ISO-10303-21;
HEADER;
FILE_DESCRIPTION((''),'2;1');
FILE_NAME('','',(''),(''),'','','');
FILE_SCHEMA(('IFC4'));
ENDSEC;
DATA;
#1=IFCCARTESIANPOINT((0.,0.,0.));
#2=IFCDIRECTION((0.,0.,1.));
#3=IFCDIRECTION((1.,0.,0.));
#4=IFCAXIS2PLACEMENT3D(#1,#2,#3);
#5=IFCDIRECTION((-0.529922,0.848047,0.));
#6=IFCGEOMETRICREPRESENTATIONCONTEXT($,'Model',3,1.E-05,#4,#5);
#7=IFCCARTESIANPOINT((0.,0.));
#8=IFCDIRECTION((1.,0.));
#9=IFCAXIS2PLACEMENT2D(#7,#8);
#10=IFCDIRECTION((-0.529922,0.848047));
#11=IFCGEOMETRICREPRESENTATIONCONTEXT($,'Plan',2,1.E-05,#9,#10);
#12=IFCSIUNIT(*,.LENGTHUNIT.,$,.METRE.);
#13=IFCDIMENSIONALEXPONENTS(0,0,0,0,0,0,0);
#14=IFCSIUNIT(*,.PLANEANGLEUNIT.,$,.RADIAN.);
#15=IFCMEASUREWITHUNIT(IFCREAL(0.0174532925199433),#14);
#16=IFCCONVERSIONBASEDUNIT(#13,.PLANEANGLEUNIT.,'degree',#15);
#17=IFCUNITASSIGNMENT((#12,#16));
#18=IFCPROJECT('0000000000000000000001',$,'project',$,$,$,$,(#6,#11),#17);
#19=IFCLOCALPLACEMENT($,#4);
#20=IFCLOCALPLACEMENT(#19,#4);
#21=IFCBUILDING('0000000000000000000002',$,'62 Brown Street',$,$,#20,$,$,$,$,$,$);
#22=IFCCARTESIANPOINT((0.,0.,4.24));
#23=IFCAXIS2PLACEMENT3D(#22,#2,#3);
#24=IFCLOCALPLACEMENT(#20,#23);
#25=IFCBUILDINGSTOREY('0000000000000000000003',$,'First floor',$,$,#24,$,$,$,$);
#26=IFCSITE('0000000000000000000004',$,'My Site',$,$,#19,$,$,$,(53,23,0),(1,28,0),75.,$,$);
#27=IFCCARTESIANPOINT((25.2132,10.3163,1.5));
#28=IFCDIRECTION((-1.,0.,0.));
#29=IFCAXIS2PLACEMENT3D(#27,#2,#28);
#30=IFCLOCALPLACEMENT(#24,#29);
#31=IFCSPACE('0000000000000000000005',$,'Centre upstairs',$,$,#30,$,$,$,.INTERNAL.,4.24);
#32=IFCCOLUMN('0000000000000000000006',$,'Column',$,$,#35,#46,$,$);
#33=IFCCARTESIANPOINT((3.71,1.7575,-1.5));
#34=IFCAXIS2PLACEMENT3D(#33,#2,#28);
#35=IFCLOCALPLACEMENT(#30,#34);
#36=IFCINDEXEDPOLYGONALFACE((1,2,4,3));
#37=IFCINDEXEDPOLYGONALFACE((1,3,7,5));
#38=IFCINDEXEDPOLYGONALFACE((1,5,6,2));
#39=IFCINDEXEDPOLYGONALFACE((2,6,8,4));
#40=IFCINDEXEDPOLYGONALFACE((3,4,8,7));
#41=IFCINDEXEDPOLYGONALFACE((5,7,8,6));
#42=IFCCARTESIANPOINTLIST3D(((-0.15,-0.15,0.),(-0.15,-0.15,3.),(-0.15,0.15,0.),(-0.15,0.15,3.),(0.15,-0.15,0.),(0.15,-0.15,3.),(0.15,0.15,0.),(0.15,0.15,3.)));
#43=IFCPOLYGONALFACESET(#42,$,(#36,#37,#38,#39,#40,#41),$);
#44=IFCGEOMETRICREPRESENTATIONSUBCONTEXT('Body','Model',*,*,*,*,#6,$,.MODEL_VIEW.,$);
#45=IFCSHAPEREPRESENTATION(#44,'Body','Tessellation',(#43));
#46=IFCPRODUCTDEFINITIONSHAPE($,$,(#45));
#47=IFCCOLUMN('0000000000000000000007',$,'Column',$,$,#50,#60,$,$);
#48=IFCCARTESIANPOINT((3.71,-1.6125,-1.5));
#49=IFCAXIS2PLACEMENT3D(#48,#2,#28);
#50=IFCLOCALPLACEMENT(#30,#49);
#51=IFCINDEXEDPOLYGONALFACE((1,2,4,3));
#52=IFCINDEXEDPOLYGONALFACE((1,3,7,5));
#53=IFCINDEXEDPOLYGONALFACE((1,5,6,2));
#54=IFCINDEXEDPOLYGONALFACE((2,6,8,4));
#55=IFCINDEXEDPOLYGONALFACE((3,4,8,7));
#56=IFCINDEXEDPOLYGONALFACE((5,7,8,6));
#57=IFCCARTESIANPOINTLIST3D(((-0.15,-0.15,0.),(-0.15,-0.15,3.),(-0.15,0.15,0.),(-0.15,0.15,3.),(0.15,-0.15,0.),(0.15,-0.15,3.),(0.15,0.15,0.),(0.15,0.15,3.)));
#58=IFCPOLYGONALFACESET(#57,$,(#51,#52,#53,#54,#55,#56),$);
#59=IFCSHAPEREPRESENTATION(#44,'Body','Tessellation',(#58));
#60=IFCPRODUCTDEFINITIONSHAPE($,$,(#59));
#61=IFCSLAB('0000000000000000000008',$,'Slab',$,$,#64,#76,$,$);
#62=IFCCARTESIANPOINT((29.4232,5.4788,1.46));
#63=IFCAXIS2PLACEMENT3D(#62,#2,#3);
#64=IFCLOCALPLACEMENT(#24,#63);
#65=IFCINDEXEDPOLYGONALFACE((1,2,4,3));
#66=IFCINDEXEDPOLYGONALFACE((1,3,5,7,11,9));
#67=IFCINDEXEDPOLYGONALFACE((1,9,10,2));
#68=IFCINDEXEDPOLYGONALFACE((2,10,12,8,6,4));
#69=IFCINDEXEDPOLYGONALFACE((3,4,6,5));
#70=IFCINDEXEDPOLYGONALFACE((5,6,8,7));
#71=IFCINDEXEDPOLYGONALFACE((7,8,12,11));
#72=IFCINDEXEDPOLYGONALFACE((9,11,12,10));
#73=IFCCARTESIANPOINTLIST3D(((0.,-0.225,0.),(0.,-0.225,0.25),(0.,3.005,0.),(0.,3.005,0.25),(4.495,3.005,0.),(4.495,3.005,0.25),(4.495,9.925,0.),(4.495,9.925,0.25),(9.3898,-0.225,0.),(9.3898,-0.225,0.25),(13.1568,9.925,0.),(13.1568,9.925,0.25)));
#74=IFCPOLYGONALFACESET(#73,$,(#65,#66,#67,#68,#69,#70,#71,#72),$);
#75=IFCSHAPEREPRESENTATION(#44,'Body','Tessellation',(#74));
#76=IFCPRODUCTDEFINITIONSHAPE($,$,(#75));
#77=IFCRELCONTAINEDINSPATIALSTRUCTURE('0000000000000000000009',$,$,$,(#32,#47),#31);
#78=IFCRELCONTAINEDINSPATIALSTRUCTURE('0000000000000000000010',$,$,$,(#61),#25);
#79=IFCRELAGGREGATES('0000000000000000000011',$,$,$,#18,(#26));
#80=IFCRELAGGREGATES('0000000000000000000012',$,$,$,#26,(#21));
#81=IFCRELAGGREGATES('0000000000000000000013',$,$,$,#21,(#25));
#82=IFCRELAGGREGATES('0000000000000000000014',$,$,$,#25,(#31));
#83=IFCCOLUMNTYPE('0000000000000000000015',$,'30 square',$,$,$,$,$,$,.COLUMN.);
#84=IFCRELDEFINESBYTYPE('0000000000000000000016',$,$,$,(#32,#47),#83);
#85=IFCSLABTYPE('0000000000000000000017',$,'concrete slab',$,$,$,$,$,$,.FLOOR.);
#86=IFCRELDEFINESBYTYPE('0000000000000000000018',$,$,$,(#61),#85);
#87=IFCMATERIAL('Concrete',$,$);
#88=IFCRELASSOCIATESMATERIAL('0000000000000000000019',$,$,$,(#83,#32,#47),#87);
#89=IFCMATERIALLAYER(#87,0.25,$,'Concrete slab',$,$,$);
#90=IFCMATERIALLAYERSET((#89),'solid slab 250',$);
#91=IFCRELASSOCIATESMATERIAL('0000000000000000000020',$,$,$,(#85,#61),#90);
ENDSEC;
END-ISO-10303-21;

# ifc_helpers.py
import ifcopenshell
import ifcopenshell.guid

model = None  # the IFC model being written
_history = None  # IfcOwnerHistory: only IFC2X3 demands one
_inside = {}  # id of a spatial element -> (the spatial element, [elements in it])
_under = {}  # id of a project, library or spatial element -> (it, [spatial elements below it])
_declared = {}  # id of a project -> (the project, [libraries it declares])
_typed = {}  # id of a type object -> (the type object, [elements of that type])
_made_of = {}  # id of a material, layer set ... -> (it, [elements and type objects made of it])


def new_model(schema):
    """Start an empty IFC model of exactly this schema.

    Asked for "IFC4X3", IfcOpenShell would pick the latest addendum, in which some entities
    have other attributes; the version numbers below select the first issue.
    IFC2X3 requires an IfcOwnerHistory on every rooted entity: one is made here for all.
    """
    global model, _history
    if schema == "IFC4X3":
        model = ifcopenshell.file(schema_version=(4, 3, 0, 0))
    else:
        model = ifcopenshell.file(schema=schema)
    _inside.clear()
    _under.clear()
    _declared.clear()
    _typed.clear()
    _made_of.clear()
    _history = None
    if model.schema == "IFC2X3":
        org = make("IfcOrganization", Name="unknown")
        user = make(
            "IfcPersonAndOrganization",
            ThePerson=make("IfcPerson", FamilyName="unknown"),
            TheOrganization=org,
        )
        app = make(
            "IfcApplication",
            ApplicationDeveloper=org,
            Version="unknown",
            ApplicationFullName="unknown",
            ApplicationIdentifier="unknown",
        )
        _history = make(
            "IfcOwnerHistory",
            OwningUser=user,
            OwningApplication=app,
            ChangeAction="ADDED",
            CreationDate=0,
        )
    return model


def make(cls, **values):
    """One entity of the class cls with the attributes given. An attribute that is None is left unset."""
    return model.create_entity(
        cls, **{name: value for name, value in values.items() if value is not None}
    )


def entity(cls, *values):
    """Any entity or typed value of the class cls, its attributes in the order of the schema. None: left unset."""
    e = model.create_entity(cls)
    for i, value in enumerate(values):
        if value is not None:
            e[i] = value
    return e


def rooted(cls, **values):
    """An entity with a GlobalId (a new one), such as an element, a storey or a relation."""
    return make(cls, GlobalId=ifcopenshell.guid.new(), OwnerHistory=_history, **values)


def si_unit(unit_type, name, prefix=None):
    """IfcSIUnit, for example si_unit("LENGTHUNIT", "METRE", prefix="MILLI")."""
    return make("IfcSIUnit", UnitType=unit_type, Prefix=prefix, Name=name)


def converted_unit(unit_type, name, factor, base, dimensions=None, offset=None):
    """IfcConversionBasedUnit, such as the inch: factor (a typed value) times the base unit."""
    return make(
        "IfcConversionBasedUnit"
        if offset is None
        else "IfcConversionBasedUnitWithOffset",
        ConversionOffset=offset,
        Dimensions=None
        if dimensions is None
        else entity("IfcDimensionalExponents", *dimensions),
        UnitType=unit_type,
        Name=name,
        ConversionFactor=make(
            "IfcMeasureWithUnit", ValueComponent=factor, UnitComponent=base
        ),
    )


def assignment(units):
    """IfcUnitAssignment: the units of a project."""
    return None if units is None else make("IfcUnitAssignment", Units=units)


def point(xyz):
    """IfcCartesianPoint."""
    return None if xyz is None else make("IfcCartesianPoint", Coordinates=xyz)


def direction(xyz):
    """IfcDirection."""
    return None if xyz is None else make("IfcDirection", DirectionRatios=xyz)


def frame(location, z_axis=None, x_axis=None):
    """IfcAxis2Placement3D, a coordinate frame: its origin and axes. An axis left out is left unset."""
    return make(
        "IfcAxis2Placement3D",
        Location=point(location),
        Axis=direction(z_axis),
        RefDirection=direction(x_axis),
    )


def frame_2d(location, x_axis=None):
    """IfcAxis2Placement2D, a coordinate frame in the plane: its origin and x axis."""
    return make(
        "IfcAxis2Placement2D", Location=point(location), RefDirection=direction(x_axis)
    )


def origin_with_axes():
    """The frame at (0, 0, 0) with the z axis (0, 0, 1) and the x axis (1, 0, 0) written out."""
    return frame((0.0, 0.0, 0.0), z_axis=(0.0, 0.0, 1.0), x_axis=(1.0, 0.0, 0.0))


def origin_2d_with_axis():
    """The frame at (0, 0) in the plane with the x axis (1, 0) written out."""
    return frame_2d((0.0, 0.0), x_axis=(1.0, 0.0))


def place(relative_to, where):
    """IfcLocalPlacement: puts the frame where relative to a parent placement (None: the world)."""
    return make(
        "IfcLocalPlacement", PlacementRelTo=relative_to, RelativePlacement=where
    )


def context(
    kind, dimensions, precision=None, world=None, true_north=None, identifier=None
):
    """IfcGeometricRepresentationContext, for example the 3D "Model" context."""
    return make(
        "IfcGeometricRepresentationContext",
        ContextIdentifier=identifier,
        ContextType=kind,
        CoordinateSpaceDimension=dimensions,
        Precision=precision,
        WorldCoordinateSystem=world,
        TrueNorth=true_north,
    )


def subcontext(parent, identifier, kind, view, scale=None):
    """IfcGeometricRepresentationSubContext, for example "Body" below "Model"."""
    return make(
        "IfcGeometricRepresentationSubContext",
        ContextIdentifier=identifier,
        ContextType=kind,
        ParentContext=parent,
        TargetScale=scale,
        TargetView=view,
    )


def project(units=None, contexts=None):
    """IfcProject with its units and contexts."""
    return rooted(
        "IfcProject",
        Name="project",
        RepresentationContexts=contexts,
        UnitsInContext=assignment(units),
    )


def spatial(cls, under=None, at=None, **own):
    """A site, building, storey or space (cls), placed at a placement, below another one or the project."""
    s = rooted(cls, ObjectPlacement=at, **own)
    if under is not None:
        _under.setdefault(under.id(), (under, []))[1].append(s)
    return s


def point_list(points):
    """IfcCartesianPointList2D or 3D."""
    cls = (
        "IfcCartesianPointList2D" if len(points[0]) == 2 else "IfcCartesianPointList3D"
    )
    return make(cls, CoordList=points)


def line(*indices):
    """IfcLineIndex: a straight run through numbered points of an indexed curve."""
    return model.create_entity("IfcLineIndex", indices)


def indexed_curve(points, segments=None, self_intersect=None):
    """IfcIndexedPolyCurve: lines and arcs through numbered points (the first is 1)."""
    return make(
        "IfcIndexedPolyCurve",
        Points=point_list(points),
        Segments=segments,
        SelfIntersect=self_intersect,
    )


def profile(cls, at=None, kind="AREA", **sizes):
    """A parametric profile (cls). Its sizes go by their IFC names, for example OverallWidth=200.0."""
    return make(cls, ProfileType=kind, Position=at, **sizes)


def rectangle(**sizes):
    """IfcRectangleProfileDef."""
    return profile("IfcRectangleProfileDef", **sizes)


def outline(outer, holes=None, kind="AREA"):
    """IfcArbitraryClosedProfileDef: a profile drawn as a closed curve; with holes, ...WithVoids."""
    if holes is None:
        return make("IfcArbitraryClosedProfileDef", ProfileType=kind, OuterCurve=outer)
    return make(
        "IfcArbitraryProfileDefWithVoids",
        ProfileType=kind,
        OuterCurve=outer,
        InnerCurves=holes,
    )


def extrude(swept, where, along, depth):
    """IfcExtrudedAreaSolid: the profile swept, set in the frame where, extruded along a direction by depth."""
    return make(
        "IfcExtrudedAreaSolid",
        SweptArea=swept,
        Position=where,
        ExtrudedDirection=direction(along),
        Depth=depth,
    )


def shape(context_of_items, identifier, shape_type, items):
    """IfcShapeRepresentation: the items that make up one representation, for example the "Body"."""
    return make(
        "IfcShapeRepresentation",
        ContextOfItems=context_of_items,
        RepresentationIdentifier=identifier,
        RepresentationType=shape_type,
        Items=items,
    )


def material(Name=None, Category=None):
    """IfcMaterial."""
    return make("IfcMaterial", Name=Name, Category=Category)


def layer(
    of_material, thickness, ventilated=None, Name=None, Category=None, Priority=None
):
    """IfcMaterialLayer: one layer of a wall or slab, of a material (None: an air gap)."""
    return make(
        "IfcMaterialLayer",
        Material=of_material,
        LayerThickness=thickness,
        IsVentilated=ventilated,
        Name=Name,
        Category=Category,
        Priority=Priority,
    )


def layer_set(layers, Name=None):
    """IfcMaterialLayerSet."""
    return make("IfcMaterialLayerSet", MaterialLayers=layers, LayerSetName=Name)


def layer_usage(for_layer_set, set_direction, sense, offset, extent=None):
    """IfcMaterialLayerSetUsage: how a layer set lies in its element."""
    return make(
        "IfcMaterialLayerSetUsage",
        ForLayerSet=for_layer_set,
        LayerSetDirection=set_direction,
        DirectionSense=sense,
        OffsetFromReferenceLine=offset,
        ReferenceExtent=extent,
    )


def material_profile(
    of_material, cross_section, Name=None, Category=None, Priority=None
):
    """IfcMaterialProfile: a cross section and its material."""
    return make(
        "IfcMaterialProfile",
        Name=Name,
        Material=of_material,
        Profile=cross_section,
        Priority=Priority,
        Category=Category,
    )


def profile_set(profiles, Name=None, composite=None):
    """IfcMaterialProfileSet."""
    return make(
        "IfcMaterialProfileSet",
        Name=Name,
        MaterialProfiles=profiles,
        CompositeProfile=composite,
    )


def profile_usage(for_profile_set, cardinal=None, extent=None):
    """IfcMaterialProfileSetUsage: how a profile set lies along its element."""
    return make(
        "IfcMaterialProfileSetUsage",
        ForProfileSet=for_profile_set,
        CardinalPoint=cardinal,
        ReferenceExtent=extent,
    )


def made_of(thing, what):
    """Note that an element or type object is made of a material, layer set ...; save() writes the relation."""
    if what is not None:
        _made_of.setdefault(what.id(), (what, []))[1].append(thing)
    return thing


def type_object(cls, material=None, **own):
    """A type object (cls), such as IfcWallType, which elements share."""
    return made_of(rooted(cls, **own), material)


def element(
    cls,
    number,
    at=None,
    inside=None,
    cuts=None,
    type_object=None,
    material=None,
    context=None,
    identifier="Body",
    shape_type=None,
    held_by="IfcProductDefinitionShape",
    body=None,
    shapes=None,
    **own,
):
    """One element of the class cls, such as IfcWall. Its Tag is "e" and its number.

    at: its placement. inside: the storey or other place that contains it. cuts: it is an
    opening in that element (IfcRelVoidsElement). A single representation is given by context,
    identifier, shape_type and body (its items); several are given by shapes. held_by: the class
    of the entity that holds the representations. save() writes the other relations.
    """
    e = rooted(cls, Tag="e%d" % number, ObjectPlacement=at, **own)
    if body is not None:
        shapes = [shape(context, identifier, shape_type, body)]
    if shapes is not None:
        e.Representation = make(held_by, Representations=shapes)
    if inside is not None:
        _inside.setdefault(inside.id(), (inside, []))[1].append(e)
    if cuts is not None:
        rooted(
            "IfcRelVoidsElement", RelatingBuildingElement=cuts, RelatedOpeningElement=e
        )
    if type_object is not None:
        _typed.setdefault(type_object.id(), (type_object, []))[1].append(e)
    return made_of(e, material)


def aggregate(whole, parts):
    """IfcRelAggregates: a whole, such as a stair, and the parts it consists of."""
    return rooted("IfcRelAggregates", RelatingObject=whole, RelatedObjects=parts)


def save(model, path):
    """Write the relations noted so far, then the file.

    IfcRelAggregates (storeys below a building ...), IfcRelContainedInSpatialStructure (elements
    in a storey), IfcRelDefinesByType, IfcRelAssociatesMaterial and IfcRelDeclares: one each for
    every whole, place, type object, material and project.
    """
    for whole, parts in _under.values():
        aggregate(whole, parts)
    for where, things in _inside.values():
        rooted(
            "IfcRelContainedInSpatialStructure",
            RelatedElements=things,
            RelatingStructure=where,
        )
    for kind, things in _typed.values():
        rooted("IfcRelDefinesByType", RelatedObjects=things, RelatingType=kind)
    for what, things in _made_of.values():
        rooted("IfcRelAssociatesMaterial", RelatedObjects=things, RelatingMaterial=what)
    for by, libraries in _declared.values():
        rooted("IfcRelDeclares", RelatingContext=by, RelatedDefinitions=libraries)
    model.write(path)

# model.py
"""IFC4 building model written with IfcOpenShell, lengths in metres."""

from ifc_helpers import new_model, entity, si_unit, converted_unit, direction, frame, origin_with_axes, origin_2d_with_axis, place, context, subcontext, project, spatial, line, indexed_curve, rectangle, outline, extrude, material, layer, layer_set, layer_usage, material_profile, profile_set, profile_usage, type_object, element, save


model = new_model("IFC4")

# Units and contexts
model_context = context("Model", 3, precision=1e-05, world=origin_with_axes(), true_north=direction((-0.529922, 0.848047, 0.0)))
plan_context = context("Plan", 2, precision=1e-05, world=origin_2d_with_axis(), true_north=direction((-0.529922, 0.848047)))
body_context_1 = subcontext(model_context, "Body", "Model", "MODEL_VIEW")
ifc_project = project(units=[si_unit("LENGTHUNIT", "METRE"), converted_unit("PLANEANGLEUNIT", "degree", entity("IfcReal", 0.0174532925199433), si_unit("PLANEANGLEUNIT", "RADIAN"), dimensions=[0, 0, 0, 0, 0, 0, 0])], contexts=[model_context, plan_context])

# Site, building, storey, space
site_placement = place(None, origin_with_axes())
site = spatial("IfcSite", under=ifc_project, at=site_placement, Name="My Site", RefLatitude=(53, 23, 0), RefLongitude=(1, 28, 0), RefElevation=75.0)
building_placement = place(site_placement, origin_with_axes())
building = spatial("IfcBuilding", under=site, at=building_placement, Name="62 Brown Street")
storey_placement = place(building_placement, frame((0.0, 0.0, 4.24), z_axis=(0.0, 0.0, 1.0), x_axis=(1.0, 0.0, 0.0)))
storey = spatial("IfcBuildingStorey", under=building, at=storey_placement, Name="First floor")
space_placement = place(storey_placement, frame((25.2132, 10.3163, 1.5), z_axis=(0.0, 0.0, 1.0), x_axis=(-1.0, 0.0, 0.0)))
space = spatial("IfcSpace", under=storey, at=space_placement, Name="Centre upstairs", PredefinedType="INTERNAL", ElevationWithFlooring=4.24)

# Columns
ifc_material_1 = material(Name="Concrete")
ifc_material_profile = material_profile(ifc_material_1, rectangle(XDim=0.3, YDim=0.3))
ifc_profile_set = profile_set([ifc_material_profile])
ifc_profile_usage_1 = profile_usage(ifc_profile_set, cardinal=5)
column_type = type_object("IfcColumnType", Name="30 square", PredefinedType="COLUMN", material=ifc_profile_set)
column_1_placement = place(space_placement, frame((3.71, 1.7575, -1.5), z_axis=(0.0, 0.0, 1.0), x_axis=(-1.0, 0.0, 0.0)))
element("IfcColumn", 1, at=column_1_placement, inside=space, type_object=column_type, material=ifc_profile_usage_1, Name="Column", context=body_context_1, shape_type="SweptSolid", body=[
    extrude(rectangle(XDim=0.3, YDim=0.3), origin_with_axes(), (0.0, 0.0, 1.0), 3.0),
])
ifc_profile_usage_2 = profile_usage(ifc_profile_set, cardinal=5)
column_2_placement = place(space_placement, frame((3.71, -1.6125, -1.5), z_axis=(0.0, 0.0, 1.0), x_axis=(-1.0, 0.0, 0.0)))
element("IfcColumn", 2, at=column_2_placement, inside=space, type_object=column_type, material=ifc_profile_usage_2, Name="Column", context=body_context_1, shape_type="SweptSolid", body=[
    extrude(rectangle(XDim=0.3, YDim=0.3), origin_with_axes(), (0.0, 0.0, 1.0), 3.0),
])

# Slab
ifc_layer_1 = layer(ifc_material_1, 0.25, Name="Concrete slab")
ifc_layer_set_1 = layer_set([ifc_layer_1], Name="solid slab 250")
slab_type = type_object("IfcSlabType", Name="concrete slab", PredefinedType="FLOOR", material=ifc_layer_set_1)
ifc_layer_usage_1 = layer_usage(ifc_layer_set_1, "AXIS3", "POSITIVE", 0.0)
slab_1_placement = place(storey_placement, frame((29.4232, 5.4788, 1.46), z_axis=(0.0, 0.0, 1.0), x_axis=(1.0, 0.0, 0.0)))
element("IfcSlab", 3, at=slab_1_placement, inside=storey, type_object=slab_type, material=ifc_layer_usage_1, Name="Slab", context=body_context_1, shape_type="SweptSolid", body=[
    extrude(outline(indexed_curve([(0.0, 3.005), (0.0, -0.225), (9.3898, -0.225), (13.1568, 9.925), (4.495, 9.925), (4.495, 3.005)], segments=[line(4, 3), line(3, 2), line(2, 1), line(1, 6), line(6, 5), line(5, 4)], self_intersect=False)), None, (0.0, 0.0, 1.0), 0.25),
])

save(model, "model.ifc")
